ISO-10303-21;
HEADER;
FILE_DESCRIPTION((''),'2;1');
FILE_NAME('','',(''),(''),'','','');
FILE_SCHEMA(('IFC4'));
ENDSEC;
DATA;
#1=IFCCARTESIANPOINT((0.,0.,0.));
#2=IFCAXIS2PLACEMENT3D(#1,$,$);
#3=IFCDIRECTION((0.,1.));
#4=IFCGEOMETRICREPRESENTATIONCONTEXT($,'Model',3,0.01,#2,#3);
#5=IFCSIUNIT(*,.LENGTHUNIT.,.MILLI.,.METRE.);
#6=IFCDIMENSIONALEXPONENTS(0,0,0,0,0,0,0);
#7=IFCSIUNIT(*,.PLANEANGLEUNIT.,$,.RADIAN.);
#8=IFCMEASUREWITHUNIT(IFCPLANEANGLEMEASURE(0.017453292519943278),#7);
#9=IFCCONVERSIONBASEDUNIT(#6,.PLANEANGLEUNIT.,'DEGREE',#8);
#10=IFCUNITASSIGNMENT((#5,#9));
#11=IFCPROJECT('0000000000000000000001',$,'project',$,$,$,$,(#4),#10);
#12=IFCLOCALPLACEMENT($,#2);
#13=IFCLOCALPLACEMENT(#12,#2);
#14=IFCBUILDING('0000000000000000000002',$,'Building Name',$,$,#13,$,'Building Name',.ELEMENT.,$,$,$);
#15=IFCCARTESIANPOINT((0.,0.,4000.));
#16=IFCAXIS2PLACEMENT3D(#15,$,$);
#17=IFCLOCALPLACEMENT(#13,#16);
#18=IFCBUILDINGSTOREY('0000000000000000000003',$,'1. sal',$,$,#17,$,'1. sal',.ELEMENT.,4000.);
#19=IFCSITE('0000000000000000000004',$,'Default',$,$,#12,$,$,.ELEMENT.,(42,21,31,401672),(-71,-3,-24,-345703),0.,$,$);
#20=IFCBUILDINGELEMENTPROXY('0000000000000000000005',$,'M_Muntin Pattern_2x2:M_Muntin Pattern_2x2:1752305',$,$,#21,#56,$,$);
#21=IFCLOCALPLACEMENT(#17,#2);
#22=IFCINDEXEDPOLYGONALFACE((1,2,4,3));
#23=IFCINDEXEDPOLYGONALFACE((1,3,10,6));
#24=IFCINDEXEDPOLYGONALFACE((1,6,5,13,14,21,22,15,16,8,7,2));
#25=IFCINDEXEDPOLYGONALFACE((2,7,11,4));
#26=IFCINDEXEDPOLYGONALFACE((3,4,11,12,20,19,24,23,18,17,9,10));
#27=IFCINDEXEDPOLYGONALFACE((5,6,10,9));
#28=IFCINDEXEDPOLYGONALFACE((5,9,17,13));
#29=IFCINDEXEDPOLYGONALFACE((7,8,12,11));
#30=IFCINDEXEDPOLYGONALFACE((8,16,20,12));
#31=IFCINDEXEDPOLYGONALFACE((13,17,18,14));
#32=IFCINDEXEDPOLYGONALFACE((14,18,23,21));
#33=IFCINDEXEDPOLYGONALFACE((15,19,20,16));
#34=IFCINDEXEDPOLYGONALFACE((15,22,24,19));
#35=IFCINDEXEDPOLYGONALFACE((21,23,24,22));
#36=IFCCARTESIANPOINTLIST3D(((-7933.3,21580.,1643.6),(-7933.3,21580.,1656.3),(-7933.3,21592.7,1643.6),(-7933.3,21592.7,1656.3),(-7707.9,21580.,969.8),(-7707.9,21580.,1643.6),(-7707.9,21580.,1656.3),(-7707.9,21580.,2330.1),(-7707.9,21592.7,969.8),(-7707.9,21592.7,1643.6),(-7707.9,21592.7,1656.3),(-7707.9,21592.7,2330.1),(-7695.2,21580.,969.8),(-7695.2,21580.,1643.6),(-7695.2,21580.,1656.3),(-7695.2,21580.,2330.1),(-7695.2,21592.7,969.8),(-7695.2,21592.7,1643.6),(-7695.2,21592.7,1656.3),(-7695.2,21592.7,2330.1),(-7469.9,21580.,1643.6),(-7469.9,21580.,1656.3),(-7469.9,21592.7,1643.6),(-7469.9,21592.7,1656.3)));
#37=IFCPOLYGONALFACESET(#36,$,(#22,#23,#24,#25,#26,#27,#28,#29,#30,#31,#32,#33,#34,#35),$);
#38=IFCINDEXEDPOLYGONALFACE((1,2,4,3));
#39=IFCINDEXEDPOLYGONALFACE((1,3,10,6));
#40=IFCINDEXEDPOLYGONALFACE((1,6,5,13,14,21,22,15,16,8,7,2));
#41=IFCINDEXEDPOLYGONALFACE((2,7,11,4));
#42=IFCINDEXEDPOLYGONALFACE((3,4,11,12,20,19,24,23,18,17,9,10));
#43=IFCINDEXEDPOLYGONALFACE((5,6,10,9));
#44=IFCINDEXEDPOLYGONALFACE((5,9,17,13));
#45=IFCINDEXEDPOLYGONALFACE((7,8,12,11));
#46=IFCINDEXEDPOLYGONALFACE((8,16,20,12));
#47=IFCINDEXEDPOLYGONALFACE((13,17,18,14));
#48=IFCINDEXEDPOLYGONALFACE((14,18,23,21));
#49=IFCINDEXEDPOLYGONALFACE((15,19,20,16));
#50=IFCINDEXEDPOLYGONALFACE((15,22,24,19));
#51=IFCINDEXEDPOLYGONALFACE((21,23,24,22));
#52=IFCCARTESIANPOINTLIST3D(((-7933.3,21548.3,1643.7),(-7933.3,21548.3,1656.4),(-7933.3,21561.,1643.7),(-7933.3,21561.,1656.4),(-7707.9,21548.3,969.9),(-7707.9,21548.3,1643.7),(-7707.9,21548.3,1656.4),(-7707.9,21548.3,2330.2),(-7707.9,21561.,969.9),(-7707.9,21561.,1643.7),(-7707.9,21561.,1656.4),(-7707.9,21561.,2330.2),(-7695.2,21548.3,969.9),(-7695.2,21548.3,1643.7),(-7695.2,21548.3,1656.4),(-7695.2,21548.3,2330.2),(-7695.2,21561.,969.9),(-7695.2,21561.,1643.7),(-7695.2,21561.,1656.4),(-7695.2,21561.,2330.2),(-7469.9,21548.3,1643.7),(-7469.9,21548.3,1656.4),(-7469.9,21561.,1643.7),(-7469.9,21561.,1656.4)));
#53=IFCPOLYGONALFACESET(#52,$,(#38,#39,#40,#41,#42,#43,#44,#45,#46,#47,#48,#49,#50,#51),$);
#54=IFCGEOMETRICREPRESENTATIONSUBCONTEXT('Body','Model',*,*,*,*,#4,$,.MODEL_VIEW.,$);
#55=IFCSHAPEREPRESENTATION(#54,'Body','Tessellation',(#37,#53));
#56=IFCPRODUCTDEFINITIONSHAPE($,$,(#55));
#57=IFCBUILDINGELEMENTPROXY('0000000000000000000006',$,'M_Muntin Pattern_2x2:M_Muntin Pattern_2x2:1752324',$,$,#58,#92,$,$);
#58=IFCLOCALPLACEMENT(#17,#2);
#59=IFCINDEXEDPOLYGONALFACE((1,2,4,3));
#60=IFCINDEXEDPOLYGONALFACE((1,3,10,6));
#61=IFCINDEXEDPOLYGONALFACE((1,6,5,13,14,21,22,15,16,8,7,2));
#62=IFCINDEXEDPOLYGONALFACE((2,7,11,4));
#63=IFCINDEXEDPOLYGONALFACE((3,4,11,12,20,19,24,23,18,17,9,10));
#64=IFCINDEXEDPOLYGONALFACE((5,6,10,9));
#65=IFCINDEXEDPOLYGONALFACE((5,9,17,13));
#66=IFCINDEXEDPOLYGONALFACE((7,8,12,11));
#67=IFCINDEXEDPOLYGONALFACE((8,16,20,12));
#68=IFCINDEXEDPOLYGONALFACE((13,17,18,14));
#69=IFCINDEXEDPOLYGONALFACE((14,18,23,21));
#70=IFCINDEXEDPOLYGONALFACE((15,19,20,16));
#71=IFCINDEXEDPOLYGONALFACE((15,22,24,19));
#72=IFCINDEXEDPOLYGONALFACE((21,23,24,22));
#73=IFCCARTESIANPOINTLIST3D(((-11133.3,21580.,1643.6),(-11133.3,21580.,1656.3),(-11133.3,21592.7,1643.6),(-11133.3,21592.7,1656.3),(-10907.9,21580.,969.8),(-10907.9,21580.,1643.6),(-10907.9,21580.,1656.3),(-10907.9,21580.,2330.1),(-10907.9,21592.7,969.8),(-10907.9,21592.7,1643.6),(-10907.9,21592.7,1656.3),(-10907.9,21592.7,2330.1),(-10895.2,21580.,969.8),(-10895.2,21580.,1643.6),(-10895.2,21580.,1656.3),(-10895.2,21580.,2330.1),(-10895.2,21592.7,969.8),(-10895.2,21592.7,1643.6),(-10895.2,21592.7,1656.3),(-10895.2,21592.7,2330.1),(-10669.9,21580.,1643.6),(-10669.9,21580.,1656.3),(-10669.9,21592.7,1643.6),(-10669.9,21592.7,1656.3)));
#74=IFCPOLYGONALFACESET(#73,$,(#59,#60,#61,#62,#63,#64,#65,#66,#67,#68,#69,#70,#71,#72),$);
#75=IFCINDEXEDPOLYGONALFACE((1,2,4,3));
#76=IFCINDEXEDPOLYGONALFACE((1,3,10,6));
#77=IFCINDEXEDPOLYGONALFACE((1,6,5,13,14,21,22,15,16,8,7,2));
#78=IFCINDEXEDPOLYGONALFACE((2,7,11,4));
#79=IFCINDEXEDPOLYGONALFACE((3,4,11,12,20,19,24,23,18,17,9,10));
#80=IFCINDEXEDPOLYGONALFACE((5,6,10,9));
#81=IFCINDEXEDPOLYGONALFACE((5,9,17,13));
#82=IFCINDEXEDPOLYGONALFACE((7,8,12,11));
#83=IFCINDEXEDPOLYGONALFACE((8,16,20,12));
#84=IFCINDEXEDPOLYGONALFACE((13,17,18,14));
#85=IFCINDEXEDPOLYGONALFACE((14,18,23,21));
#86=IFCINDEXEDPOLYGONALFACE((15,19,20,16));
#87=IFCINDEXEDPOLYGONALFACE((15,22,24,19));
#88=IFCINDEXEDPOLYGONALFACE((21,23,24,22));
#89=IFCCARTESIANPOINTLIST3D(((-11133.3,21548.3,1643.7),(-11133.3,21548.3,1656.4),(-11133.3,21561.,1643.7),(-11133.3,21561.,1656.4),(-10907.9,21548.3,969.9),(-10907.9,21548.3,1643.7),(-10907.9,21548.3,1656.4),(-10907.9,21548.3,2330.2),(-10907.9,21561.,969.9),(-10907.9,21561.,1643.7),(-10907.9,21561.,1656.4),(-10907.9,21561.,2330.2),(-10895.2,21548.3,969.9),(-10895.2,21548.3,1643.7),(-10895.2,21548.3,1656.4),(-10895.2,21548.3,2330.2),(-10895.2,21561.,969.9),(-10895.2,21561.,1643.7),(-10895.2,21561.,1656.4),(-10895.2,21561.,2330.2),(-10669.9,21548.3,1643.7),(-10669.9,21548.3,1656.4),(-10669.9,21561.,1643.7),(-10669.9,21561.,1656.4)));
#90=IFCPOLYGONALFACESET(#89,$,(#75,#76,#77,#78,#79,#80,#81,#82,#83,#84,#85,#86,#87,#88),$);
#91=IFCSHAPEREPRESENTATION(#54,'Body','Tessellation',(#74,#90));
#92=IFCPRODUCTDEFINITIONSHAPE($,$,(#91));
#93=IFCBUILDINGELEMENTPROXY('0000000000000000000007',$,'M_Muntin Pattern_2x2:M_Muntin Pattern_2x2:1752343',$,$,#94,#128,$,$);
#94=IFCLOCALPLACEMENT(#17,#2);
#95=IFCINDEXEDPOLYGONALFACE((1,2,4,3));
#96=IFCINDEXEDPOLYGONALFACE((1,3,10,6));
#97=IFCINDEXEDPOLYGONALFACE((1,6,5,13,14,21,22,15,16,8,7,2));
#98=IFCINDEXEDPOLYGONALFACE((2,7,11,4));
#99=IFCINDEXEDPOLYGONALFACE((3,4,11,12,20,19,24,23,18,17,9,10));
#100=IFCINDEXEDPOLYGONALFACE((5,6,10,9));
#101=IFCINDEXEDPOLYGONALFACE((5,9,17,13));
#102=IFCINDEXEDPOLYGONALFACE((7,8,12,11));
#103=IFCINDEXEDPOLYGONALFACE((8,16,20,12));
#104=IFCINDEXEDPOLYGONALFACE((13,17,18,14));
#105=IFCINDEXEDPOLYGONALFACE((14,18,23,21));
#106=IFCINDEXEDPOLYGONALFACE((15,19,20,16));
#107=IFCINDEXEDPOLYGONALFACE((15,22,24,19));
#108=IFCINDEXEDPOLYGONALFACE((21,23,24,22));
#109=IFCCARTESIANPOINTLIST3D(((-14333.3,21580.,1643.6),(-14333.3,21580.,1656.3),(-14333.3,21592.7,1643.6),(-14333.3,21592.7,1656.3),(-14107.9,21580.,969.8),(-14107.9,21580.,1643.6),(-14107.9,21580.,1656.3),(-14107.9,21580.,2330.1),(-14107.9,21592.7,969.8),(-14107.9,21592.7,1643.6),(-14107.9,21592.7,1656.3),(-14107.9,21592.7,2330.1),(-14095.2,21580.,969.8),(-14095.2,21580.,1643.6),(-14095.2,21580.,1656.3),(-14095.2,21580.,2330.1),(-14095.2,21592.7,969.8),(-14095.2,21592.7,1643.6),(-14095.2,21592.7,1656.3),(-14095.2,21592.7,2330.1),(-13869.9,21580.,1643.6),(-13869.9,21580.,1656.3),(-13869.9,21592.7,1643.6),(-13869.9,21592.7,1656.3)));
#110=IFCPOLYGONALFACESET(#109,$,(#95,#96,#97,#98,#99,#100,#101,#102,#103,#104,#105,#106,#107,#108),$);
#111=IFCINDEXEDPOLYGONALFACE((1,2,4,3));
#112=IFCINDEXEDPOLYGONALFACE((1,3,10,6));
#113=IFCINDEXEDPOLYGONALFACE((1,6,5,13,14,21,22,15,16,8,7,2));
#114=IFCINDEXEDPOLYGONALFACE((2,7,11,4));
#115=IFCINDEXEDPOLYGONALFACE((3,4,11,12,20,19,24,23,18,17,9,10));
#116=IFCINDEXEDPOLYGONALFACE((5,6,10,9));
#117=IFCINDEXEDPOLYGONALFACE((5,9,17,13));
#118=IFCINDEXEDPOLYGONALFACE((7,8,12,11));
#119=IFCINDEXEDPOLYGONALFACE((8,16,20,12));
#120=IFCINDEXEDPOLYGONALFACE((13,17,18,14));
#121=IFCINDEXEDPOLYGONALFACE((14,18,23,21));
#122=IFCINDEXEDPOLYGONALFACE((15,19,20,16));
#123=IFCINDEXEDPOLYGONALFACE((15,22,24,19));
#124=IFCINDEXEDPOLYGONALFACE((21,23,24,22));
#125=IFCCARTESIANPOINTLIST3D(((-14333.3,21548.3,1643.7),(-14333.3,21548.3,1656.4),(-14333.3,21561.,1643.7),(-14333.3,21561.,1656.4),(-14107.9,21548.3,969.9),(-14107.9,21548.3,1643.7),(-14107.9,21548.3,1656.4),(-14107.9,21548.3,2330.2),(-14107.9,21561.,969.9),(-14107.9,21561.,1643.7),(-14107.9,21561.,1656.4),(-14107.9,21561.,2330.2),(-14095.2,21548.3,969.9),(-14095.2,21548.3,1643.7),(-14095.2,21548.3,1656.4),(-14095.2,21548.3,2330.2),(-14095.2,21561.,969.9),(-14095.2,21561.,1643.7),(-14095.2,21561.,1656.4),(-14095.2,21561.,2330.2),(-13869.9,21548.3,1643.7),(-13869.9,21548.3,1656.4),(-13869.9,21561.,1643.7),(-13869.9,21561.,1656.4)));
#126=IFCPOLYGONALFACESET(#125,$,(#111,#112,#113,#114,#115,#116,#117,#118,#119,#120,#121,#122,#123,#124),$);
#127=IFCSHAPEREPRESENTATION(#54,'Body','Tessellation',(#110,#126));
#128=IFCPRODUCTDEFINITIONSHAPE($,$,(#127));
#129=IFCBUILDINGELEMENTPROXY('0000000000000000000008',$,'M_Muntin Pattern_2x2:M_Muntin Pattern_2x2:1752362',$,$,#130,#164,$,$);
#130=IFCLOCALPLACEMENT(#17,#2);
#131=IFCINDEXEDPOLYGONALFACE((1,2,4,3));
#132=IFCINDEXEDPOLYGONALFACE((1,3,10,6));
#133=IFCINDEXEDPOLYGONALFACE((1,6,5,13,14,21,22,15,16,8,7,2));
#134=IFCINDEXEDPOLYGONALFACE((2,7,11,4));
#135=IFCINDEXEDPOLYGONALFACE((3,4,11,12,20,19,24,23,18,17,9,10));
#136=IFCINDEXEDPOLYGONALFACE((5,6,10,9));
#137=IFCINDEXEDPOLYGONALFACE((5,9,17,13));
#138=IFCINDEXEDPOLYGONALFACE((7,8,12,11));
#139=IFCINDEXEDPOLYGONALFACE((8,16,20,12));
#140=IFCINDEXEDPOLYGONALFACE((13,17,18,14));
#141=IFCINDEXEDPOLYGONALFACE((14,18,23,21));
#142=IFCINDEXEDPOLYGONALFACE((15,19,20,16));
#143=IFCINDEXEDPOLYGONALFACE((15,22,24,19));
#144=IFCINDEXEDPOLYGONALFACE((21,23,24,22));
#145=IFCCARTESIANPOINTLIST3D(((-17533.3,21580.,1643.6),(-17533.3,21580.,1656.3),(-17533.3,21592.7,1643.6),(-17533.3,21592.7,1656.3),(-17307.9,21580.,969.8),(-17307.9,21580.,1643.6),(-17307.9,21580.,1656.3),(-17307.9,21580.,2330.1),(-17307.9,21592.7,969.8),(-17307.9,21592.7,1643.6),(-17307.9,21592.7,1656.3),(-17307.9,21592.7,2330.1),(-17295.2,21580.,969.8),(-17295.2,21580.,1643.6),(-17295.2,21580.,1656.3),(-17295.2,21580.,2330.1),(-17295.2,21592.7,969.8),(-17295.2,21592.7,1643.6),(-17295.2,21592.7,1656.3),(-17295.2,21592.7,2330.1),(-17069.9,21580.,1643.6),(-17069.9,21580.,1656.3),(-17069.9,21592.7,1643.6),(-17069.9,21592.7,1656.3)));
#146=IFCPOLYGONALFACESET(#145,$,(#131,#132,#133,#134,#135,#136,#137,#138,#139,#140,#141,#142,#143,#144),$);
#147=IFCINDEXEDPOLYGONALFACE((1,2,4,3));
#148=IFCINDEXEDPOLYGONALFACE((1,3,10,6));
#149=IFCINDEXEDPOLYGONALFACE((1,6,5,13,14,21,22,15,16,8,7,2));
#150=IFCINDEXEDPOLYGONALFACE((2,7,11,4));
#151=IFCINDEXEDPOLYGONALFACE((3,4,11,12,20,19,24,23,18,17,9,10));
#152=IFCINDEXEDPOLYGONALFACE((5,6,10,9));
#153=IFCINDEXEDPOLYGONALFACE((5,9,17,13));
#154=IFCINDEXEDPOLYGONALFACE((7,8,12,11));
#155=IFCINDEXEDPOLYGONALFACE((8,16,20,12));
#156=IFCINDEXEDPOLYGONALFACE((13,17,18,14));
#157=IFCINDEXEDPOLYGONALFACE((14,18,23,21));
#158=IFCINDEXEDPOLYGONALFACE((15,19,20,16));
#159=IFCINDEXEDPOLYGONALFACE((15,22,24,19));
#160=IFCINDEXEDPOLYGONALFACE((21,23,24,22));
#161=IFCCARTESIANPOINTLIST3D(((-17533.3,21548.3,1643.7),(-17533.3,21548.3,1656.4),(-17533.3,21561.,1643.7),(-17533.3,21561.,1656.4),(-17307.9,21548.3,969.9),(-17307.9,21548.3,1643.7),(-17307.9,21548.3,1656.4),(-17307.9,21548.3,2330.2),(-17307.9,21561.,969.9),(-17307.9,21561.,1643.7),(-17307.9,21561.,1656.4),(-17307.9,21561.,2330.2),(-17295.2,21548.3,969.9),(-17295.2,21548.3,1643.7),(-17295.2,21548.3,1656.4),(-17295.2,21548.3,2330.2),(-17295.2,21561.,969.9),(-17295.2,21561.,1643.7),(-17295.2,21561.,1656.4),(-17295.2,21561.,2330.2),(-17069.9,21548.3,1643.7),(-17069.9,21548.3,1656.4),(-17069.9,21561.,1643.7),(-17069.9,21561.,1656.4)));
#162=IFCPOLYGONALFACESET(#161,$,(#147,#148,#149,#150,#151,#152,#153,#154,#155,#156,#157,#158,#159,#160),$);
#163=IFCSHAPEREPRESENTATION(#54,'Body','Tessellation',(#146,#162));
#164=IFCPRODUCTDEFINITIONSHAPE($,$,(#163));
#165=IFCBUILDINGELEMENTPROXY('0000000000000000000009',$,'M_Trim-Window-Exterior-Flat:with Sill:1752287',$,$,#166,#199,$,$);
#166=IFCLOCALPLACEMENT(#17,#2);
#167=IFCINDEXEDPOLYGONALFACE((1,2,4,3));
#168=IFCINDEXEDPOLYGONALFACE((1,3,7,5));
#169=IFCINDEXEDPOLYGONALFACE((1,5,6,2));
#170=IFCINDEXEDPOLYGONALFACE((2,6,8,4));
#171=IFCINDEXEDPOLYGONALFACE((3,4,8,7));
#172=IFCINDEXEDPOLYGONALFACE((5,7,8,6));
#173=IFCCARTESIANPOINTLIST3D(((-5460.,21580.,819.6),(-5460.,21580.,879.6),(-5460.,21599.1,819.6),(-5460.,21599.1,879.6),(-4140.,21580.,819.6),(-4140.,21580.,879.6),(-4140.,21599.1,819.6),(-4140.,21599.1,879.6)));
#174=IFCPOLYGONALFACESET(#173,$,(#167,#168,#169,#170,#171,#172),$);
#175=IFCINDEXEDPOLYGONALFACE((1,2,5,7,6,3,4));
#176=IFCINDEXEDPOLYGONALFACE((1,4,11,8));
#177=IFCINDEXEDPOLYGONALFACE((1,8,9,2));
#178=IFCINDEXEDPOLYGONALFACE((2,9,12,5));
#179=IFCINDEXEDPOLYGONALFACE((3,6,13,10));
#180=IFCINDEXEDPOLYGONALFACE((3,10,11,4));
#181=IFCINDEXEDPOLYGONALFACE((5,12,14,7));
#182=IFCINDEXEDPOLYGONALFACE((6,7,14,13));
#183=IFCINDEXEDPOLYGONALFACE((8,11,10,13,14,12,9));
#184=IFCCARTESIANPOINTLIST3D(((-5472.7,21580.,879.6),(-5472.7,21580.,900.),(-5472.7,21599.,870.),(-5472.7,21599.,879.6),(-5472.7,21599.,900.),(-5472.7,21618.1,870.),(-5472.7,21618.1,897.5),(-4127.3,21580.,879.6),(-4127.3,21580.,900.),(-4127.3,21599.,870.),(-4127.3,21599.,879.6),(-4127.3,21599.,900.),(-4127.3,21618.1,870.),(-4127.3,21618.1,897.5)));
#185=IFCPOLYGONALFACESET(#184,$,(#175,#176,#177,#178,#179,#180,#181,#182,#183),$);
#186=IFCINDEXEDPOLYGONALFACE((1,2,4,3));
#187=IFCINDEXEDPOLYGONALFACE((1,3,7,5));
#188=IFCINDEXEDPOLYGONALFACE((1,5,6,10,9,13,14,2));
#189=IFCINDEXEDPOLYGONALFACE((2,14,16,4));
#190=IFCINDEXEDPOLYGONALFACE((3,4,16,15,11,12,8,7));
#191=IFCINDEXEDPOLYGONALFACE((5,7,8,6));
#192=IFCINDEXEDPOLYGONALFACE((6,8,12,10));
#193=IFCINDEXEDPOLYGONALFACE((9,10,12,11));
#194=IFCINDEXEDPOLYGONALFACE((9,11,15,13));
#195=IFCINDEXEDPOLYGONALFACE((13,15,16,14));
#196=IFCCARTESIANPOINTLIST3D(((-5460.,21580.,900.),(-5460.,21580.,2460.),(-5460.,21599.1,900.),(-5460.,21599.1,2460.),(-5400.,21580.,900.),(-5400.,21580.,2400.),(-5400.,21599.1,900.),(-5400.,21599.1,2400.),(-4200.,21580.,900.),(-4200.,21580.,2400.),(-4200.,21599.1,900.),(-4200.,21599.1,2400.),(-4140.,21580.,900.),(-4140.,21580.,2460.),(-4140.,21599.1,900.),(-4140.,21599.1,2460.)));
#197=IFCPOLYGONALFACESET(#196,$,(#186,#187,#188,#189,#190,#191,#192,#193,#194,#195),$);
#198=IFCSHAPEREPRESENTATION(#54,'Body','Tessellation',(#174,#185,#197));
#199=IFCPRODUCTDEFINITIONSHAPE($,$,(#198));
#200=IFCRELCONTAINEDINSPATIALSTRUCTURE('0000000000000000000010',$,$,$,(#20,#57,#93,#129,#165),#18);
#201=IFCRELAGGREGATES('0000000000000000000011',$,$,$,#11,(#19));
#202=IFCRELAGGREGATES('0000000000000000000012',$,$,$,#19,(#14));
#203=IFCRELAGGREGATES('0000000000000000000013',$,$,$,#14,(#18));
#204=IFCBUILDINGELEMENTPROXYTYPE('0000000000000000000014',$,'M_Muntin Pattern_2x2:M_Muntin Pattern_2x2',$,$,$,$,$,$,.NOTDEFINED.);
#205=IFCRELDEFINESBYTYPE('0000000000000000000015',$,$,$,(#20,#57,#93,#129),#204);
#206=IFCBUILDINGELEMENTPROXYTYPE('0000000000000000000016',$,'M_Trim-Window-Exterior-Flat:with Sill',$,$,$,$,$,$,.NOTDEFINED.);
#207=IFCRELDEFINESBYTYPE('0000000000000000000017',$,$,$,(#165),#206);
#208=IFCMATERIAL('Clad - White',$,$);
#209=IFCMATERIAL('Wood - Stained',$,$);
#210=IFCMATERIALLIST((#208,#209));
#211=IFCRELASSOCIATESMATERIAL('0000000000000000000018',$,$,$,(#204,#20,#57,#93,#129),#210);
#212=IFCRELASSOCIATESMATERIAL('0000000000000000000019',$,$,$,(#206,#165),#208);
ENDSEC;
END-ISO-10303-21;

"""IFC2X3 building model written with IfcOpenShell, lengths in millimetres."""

from ifc_helpers import new_model, entity, si_unit, converted_unit, direction, frame, frame_2d, origin, place, context, subcontext, project, spatial, polyline, rectangle, outline, extrude, source, transform, mapped, material, material_list, type_object, type_shapes, element, save


model = new_model("IFC2X3")

# Units and contexts
model_context = context("Model", 3, precision=0.01, world=origin(), true_north=direction((0.0, 1.0)))
body_context = subcontext(model_context, "Body", "Model", "MODEL_VIEW")
ifc_project = project(units=[si_unit("LENGTHUNIT", "METRE", prefix="MILLI"), converted_unit("PLANEANGLEUNIT", "DEGREE", entity("IfcPlaneAngleMeasure", 0.017453292519943278), si_unit("PLANEANGLEUNIT", "RADIAN"), dimensions=[0, 0, 0, 0, 0, 0, 0])], contexts=[model_context])

# Site, building, storey
site_placement = place(None, origin())
site = spatial("IfcSite", under=ifc_project, at=site_placement, Name="Default", CompositionType="ELEMENT", RefLatitude=(42, 21, 31, 401672), RefLongitude=(-71, -3, -24, -345703), RefElevation=0.0)
building_placement = place(site_placement, origin())
building = spatial("IfcBuilding", under=site, at=building_placement, Name="Building Name", LongName="Building Name", CompositionType="ELEMENT")
storey_placement = place(building_placement, frame((0.0, 0.0, 4000.0)))
storey = spatial("IfcBuildingStorey", under=building, at=storey_placement, Name="1. sal", LongName="1. sal", CompositionType="ELEMENT", Elevation=4000.0)

# Building element proxies
ifc_material_1 = material(Name="Clad - White")
ifc_material_2 = material(Name="Wood - Stained")
ifc_material_list = material_list([ifc_material_1, ifc_material_2])
building_element_proxy_type_1 = type_object("IfcBuildingElementProxyType", Name="M_Muntin Pattern_2x2:M_Muntin Pattern_2x2", PredefinedType="NOTDEFINED", material=ifc_material_list)
shared_shape_1 = source(origin(), body_context, "Body", "SweptSolid", [
    extrude(outline(polyline([(6.4, -6.4), (680.1, -6.4), (680.1, 6.3), (6.4, 6.3), (6.4, 231.7), (-6.3, 231.7), (-6.3, 6.3), (-680.2, 6.3), (-680.2, -6.4), (-6.3, -6.4), (-6.3, -231.7), (6.4, -231.7), (6.4, -6.4)])), frame((0.0, -22.2, 680.1), z_axis=(0.0, 1.0, 0.0), x_axis=(0.0, 0.0, 1.0)), (0.0, 0.0, 1.0), 12.7),
    extrude(outline(polyline([(6.4, -6.4), (680.2, -6.4), (680.2, 6.3), (6.4, 6.3), (6.4, 231.7), (-6.3, 231.7), (-6.3, 6.3), (-680.2, 6.3), (-680.2, -6.4), (-6.3, -6.4), (-6.3, -231.7), (6.4, -231.7), (6.4, -6.4)])), frame((0.0, 9.5, 680.2), z_axis=(0.0, 1.0, 0.0), x_axis=(0.0, 0.0, 1.0)), (0.0, 0.0, 1.0), 12.7),
])
type_shapes(building_element_proxy_type_1, [shared_shape_1])
for number, where, z_axis, x_axis, name in (
    (1, (-7701.6, 21570.5, 969.9), (0.0, 0.0, 1.0), (-1.0, 0.0, 0.0), "M_Muntin Pattern_2x2:M_Muntin Pattern_2x2:1752305"),
    (2, (-10901.6, 21570.5, 969.9), (0.0, 0.0, 1.0), (-1.0, 0.0, 0.0), "M_Muntin Pattern_2x2:M_Muntin Pattern_2x2:1752324"),
    (3, (-14101.6, 21570.5, 969.9), (0.0, 0.0, 1.0), (-1.0, 0.0, 0.0), "M_Muntin Pattern_2x2:M_Muntin Pattern_2x2:1752343"),
    (4, (-17301.6, 21570.5, 969.9), (0.0, 0.0, 1.0), (-1.0, 0.0, 0.0), "M_Muntin Pattern_2x2:M_Muntin Pattern_2x2:1752362"),
):
    element("IfcBuildingElementProxy", number, at=place(storey_placement, frame(where, z_axis=z_axis, x_axis=x_axis)), inside=storey, type_object=building_element_proxy_type_1, material=ifc_material_list, Name=name, context=body_context, shape_type="MappedRepresentation", body=[
        mapped(shared_shape_1, transform((0.0, 0.0, 0.0), scale=1.0)),
    ])
building_element_proxy_type_2 = type_object("IfcBuildingElementProxyType", Name="M_Trim-Window-Exterior-Flat:with Sill", PredefinedType="NOTDEFINED", material=ifc_material_1)
shared_shape_2 = source(origin(), body_context, "Body", "SweptSolid", [
    extrude(rectangle(XDim=1320.0, YDim=60.0, at=frame_2d((0.0, 0.0), x_axis=(1.0, 0.0))), frame((0.0, -1550.4, 0.0), z_axis=(0.0, 0.0, 1.0), x_axis=(-1.0, 0.0, 0.0)), (0.0, 0.0, 1.0), 19.0),
    extrude(outline(polyline([(-19.0, -15.2), (0.0, -15.2), (0.0, -5.7), (19.0, -5.7), (19.0, 14.8), (0.0, 14.8), (-19.0, 12.3), (-19.0, -15.2)])), frame((-672.7, -1514.8, 19.0), z_axis=(1.0, 0.0, 0.0), x_axis=(0.0, 0.0, -1.0)), (0.0, 0.0, 1.0), 1345.4),
    extrude(outline(polyline([(-795.0, -660.0), (765.0, -660.0), (765.0, -600.0), (-735.0, -600.0), (-735.0, 600.0), (765.0, 600.0), (765.0, 660.0), (-795.0, 660.0), (-795.0, -660.0)])), frame((0.0, -735.0, 0.0), z_axis=(0.0, 0.0, 1.0), x_axis=(0.0, -1.0, 0.0)), (0.0, 0.0, 1.0), 19.0),
])
type_shapes(building_element_proxy_type_2, [shared_shape_2])
for number, where, z_axis, x_axis, name in (
    (5, (-4800.0, 21580.0, 2400.0), (0.0, 1.0, 0.0), (-1.0, 0.0, 0.0), "M_Trim-Window-Exterior-Flat:with Sill:1752287"),
):
    element("IfcBuildingElementProxy", number, at=place(storey_placement, frame(where, z_axis=z_axis, x_axis=x_axis)), inside=storey, type_object=building_element_proxy_type_2, material=ifc_material_1, Name=name, context=body_context, shape_type="MappedRepresentation", body=[
        mapped(shared_shape_2, transform((0.0, 0.0, 0.0), scale=1.0)),
    ])

save(model, "model.ifc")
